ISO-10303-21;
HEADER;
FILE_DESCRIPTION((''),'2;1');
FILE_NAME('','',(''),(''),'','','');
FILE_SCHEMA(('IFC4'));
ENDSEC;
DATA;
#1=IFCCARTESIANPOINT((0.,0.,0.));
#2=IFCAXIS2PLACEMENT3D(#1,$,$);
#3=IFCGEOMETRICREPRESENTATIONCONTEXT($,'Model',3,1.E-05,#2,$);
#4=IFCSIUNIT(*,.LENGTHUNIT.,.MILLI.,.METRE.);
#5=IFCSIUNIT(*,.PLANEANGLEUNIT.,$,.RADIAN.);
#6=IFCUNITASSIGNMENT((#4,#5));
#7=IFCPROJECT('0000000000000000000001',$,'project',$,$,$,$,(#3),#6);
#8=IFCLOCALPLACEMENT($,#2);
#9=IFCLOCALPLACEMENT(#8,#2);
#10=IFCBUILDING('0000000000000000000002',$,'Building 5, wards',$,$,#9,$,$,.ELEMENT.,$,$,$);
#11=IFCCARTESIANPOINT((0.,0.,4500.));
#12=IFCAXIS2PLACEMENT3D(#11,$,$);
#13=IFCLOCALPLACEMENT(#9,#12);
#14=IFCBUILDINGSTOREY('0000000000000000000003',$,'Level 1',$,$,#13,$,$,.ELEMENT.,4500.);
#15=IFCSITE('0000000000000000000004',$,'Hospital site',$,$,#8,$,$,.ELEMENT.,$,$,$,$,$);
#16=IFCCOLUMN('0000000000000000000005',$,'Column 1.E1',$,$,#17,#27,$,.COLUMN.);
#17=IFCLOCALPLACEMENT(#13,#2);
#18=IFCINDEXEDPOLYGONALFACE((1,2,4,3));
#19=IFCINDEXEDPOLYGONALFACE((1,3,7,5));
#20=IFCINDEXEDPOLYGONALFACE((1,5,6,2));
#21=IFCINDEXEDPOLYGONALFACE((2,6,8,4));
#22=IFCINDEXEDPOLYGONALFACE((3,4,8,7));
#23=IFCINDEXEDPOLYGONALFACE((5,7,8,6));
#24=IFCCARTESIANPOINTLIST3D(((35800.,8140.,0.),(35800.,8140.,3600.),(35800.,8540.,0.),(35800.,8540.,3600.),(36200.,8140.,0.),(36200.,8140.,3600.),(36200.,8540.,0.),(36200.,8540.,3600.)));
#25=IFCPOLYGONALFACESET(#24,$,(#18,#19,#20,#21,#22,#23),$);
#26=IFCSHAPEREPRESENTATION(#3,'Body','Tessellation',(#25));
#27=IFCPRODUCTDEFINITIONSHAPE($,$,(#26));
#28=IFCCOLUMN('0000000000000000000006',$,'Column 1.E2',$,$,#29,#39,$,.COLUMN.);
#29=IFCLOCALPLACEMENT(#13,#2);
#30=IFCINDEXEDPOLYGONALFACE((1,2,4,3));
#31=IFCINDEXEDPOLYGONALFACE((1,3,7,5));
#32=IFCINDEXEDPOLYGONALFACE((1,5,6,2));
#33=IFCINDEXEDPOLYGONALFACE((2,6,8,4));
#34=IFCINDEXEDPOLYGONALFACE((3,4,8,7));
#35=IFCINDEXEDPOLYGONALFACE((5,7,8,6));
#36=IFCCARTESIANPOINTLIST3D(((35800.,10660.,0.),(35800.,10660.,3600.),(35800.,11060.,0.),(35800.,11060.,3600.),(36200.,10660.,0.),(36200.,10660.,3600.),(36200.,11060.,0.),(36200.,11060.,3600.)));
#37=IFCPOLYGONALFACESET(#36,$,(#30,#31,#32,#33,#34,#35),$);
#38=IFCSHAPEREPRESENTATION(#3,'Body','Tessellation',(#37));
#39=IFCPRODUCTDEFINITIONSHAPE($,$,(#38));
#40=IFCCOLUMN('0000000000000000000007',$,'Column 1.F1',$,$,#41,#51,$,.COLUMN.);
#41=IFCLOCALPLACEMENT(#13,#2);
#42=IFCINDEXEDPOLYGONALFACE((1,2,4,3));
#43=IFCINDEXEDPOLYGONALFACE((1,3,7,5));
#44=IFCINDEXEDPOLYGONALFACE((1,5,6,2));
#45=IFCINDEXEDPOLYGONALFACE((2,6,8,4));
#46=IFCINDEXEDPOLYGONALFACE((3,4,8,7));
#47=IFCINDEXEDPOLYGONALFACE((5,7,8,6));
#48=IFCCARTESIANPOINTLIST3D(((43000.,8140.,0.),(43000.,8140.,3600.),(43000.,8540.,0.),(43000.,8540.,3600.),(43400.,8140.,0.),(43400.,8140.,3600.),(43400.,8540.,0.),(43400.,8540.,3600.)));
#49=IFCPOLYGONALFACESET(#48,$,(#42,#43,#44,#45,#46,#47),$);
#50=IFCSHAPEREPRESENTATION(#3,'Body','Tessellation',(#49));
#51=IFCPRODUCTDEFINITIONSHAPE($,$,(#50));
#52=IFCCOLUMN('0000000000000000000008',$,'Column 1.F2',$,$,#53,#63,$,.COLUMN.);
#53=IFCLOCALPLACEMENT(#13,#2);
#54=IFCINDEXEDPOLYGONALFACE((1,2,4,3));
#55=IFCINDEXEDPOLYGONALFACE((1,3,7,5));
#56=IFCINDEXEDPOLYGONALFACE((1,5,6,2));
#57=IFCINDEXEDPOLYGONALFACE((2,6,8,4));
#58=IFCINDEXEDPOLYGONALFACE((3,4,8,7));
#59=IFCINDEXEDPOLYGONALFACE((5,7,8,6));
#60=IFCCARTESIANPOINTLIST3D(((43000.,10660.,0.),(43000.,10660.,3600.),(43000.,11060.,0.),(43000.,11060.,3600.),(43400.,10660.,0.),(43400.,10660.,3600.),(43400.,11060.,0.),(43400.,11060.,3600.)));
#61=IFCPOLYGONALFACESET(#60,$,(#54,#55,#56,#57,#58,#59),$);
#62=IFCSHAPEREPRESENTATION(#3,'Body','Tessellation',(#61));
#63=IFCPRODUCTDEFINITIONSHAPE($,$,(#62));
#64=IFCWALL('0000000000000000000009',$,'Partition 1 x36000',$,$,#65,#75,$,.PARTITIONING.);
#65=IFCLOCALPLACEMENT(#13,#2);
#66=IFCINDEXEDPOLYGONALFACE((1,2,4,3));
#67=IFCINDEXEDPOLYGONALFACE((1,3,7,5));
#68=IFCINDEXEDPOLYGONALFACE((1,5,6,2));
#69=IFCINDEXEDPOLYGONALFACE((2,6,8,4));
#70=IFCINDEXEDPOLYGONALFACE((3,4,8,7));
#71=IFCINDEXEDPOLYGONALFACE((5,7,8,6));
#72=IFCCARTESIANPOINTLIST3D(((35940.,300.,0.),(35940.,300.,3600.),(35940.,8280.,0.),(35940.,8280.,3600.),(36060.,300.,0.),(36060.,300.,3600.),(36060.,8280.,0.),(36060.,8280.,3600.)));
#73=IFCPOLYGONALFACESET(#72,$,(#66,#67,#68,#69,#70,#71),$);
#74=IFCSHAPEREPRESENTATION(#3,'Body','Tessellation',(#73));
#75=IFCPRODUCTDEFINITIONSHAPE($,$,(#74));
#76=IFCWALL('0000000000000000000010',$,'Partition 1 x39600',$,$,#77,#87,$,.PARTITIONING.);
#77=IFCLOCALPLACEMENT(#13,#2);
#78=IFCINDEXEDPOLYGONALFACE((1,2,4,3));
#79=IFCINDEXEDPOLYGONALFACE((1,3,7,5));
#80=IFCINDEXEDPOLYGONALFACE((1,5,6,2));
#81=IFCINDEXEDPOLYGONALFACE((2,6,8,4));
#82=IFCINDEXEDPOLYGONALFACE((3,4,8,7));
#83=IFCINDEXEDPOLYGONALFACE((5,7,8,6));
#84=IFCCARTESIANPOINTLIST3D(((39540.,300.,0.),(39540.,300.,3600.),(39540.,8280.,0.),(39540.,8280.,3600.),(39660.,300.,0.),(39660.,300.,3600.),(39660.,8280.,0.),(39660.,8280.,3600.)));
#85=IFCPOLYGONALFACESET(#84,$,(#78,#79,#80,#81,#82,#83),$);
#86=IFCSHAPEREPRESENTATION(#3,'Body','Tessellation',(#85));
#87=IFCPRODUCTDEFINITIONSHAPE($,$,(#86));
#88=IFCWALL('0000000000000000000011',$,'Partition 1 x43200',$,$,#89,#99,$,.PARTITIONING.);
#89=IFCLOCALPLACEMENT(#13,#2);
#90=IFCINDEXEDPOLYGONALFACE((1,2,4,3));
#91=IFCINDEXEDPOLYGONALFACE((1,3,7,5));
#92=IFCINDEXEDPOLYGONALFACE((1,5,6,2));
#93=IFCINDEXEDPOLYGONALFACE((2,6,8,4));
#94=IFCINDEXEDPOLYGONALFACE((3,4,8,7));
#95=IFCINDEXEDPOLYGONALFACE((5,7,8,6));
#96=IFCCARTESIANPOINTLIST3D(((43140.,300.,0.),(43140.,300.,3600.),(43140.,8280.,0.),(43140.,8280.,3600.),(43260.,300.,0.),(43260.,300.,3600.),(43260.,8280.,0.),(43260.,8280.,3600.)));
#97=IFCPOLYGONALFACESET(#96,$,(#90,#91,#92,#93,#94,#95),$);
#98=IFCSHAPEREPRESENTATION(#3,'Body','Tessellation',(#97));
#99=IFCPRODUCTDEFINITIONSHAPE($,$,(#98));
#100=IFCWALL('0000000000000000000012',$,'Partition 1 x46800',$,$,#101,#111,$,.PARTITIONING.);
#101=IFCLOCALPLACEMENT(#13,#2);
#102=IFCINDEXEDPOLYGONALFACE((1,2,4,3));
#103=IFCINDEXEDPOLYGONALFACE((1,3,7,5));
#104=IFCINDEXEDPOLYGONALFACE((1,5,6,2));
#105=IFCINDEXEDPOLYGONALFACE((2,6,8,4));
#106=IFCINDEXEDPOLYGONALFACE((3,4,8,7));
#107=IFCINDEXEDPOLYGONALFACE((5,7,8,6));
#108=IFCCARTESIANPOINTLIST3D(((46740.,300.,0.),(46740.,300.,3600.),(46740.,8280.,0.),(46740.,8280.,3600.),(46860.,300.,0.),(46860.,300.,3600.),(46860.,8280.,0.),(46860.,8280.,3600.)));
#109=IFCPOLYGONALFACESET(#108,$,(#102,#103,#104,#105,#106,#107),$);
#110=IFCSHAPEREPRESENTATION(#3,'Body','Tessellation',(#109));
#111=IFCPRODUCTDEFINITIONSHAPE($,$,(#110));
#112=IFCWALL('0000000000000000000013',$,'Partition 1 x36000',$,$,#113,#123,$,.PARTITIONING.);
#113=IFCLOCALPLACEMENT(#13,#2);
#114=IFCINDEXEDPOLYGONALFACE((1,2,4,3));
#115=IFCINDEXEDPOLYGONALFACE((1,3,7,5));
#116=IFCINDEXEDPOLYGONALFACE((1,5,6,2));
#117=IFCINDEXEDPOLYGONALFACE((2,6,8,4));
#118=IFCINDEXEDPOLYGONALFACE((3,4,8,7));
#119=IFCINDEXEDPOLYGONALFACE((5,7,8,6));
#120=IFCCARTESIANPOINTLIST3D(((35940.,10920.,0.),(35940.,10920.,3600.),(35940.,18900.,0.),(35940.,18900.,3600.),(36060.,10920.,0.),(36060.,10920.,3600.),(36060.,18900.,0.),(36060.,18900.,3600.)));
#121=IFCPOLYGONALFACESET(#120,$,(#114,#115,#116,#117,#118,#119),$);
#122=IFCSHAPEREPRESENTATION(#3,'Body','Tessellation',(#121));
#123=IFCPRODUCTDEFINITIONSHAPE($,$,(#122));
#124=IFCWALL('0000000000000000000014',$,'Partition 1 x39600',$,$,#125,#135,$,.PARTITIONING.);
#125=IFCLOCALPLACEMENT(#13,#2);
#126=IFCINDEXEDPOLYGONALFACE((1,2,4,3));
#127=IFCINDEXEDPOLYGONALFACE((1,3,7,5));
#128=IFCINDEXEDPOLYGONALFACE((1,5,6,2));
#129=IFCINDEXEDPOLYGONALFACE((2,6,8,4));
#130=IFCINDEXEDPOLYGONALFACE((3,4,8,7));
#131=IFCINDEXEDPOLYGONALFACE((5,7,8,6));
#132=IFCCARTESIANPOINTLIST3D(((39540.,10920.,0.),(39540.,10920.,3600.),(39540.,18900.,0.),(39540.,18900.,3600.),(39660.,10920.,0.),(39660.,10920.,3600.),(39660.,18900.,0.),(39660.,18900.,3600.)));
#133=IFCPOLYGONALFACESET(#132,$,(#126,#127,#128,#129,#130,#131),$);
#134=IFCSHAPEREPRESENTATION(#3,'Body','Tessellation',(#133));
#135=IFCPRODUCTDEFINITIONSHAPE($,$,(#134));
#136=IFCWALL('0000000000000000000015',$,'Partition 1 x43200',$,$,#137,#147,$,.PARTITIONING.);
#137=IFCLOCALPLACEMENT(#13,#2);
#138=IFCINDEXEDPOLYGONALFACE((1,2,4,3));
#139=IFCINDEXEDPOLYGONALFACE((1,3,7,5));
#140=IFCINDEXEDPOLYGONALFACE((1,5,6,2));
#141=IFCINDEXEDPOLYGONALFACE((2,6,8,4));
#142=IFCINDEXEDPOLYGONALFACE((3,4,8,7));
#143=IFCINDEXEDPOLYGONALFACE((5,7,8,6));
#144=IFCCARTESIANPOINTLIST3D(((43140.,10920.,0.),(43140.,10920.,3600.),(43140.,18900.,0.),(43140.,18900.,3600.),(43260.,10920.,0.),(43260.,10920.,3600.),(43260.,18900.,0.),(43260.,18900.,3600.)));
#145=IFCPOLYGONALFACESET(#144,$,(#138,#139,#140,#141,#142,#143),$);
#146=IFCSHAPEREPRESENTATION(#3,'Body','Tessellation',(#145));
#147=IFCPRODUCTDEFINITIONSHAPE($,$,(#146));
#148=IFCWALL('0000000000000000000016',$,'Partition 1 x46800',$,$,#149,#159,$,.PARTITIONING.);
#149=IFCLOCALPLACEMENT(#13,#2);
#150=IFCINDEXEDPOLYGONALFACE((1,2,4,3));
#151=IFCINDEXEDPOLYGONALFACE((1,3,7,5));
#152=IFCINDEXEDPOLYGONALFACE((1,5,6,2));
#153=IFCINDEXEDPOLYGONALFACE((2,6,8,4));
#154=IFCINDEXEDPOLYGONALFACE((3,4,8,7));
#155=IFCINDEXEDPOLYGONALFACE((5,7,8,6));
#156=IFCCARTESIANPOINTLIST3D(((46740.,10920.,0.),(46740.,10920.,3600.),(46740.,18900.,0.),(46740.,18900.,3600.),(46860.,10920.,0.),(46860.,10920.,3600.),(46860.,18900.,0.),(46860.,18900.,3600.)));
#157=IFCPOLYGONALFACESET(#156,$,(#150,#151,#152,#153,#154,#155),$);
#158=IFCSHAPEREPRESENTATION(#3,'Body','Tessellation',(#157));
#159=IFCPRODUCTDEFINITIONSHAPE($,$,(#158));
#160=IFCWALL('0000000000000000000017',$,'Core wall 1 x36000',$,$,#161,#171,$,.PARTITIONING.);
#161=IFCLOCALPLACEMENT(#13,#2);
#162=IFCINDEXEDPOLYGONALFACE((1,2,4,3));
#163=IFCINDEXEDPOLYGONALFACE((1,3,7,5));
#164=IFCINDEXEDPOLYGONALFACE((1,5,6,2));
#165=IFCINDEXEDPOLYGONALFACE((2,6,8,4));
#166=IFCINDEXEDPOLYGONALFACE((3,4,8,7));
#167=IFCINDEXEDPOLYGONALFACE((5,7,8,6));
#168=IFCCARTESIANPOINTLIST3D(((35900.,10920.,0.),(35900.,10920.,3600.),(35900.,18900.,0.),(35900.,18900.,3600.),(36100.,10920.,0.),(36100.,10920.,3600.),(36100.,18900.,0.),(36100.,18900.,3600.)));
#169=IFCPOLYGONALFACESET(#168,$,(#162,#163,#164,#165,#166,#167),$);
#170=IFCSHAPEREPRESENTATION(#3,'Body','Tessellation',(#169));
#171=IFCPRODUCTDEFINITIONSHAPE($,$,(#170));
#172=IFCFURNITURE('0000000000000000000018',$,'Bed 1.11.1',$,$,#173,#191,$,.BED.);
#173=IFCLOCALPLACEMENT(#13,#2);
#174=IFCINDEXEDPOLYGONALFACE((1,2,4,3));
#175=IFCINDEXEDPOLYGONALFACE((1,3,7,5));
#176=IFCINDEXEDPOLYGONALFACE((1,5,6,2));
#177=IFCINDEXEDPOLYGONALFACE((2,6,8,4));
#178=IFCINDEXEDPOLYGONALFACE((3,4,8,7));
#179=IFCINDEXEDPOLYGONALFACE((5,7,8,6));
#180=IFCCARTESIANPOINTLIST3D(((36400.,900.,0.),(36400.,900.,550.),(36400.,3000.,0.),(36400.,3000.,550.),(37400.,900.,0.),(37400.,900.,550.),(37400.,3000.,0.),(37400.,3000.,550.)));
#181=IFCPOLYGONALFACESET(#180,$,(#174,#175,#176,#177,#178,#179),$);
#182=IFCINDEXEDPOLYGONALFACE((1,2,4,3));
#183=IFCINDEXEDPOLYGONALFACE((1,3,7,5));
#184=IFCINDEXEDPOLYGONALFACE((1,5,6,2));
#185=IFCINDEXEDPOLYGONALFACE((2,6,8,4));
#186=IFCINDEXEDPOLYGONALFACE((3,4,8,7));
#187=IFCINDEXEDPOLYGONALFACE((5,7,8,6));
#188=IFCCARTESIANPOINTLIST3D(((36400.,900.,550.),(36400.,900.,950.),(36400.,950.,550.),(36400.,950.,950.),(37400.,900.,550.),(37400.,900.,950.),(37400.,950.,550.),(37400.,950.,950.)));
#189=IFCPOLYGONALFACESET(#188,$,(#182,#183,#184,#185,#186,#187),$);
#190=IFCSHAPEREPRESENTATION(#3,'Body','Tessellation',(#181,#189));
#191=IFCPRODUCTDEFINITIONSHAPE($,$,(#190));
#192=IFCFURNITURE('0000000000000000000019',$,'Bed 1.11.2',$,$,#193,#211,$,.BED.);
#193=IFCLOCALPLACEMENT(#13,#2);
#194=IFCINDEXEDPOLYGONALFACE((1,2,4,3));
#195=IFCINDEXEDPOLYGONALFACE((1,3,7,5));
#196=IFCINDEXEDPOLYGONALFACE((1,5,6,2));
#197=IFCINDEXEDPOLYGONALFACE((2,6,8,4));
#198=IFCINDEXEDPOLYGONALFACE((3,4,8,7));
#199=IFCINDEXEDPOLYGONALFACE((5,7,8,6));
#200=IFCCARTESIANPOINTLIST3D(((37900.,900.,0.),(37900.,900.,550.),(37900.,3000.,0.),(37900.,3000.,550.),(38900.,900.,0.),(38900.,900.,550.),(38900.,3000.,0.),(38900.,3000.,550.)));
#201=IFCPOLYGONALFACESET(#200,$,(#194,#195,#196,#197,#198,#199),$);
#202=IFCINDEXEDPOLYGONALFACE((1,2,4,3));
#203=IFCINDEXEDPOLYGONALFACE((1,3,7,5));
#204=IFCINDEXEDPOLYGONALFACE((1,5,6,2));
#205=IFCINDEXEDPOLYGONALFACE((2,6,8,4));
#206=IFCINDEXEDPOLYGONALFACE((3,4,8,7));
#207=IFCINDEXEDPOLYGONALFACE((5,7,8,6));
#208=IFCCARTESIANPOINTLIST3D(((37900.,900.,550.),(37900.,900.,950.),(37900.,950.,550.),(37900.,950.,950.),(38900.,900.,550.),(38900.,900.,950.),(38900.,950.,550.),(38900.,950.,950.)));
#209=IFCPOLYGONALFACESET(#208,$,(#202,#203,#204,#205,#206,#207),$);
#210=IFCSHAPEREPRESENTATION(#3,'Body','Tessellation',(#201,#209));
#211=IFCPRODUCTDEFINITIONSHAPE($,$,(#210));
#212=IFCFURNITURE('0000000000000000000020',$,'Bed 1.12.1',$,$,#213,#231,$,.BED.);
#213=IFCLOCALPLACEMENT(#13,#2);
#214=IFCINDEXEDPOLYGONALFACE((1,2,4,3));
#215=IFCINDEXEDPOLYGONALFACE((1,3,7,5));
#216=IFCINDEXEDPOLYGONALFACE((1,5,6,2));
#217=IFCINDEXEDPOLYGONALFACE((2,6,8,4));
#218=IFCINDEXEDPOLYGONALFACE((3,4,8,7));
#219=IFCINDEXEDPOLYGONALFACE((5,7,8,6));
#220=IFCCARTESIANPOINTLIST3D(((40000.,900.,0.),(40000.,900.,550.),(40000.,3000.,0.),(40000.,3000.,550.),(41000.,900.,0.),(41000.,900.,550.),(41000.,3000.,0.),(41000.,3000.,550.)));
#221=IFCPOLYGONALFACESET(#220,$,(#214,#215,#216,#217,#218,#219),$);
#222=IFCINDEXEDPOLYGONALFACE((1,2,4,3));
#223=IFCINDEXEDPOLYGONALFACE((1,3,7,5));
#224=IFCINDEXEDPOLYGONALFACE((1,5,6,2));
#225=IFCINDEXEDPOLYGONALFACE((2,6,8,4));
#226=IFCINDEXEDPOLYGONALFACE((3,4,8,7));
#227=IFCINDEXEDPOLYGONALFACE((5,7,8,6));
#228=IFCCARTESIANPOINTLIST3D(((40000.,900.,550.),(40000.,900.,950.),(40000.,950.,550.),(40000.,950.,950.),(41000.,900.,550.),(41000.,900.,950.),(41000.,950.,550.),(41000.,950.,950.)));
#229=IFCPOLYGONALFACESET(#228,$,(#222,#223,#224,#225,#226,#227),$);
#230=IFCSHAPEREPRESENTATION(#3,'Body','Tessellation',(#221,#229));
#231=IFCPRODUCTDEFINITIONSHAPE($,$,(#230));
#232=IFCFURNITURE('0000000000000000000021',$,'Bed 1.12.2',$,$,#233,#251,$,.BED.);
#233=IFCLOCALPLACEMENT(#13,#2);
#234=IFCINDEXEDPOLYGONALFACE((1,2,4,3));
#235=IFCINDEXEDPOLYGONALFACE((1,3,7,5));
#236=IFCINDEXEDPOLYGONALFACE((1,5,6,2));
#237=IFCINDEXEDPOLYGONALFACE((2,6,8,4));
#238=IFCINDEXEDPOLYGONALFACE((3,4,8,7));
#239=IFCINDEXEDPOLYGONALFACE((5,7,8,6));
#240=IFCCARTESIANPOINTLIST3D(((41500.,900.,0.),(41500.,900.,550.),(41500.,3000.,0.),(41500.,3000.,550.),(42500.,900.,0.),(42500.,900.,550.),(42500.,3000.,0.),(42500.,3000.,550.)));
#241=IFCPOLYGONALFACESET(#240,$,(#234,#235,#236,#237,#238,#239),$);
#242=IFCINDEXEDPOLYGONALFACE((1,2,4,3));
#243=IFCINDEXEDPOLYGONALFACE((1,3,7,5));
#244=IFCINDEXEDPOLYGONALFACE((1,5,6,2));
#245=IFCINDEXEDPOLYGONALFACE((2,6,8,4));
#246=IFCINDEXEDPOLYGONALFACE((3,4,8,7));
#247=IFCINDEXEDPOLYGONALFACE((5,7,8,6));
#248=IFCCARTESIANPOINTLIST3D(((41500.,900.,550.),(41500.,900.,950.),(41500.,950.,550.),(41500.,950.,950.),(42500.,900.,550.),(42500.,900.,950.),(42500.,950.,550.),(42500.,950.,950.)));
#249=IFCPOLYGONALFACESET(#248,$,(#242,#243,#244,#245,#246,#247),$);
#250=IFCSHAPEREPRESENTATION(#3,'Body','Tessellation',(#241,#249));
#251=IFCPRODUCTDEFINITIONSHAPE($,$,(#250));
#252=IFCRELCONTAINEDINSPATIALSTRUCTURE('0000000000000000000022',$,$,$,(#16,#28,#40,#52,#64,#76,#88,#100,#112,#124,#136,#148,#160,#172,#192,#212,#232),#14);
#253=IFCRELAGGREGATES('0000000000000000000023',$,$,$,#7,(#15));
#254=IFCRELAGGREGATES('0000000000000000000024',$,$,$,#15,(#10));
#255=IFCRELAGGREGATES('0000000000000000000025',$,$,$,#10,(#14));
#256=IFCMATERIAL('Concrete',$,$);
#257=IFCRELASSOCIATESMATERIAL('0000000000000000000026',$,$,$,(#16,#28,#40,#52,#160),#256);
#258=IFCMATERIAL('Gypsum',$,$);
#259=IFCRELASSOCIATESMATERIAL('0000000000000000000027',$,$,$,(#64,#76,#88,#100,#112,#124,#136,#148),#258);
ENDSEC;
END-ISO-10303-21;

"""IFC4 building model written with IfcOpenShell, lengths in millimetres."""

from ifc_helpers import new_model, si_unit, frame, frame_2d, origin, origin_2d, place, context, project, spatial, rectangle, extrude, material, element, save


model = new_model("IFC4")

# Units and contexts
model_context = context("Model", 3, precision=1e-05, world=origin())
ifc_project = project(units=[si_unit("LENGTHUNIT", "METRE", prefix="MILLI"), si_unit("PLANEANGLEUNIT", "RADIAN")], contexts=[model_context])

# Site, building, storey
site_placement = place(None, origin())
site = spatial("IfcSite", under=ifc_project, at=site_placement, Name="Hospital site", CompositionType="ELEMENT")
building_placement = place(site_placement, origin())
building = spatial("IfcBuilding", under=site, at=building_placement, Name="Building 5, wards", CompositionType="ELEMENT")
storey_placement = place(building_placement, frame((0.0, 0.0, 4500.0)))
storey = spatial("IfcBuildingStorey", under=building, at=storey_placement, Name="Level 1", CompositionType="ELEMENT", Elevation=4500.0)

# Columns
ifc_material_1 = material(Name="Concrete")
for number, where, name in (
    (1, (36000.0, 8340.0, 0.0), "Column 1.E1"),
    (2, (36000.0, 10860.0, 0.0), "Column 1.E2"),
    (3, (43200.0, 8340.0, 0.0), "Column 1.F1"),
    (4, (43200.0, 10860.0, 0.0), "Column 1.F2"),
):
    element("IfcColumn", number, at=place(storey_placement, frame(where)), inside=storey, material=ifc_material_1, Name=name, PredefinedType="COLUMN", context=model_context, shape_type="SweptSolid", body=[
        extrude(rectangle(XDim=400.0, YDim=400.0, at=origin_2d()), origin(), (0.0, 0.0, 1.0), 3600.0),
    ])

# Walls
ifc_material_2 = material(Name="Gypsum")
for number, where, x_axis, name in (
    (5, (36060.0, 300.0, 0.0), (0.0, 1.0, 0.0), "Partition 1 x36000"),
    (6, (39660.0, 300.0, 0.0), (0.0, 1.0, 0.0), "Partition 1 x39600"),
    (7, (43260.0, 300.0, 0.0), (0.0, 1.0, 0.0), "Partition 1 x43200"),
    (8, (46860.0, 300.0, 0.0), (0.0, 1.0, 0.0), "Partition 1 x46800"),
    (9, (36060.0, 10920.0, 0.0), (0.0, 1.0, 0.0), "Partition 1 x36000"),
    (10, (39660.0, 10920.0, 0.0), (0.0, 1.0, 0.0), "Partition 1 x39600"),
    (11, (43260.0, 10920.0, 0.0), (0.0, 1.0, 0.0), "Partition 1 x43200"),
    (12, (46860.0, 10920.0, 0.0), (0.0, 1.0, 0.0), "Partition 1 x46800"),
):
    element("IfcWall", number, at=place(storey_placement, frame(where, x_axis=x_axis)), inside=storey, material=ifc_material_2, Name=name, PredefinedType="PARTITIONING", context=model_context, shape_type="SweptSolid", body=[
        extrude(rectangle(XDim=7980.0, YDim=120.0, at=frame_2d((3990.0, 60.0))), origin(), (0.0, 0.0, 1.0), 3600.0),
    ])
wall_placement = place(storey_placement, frame((36100.0, 10920.0, 0.0), x_axis=(0.0, 1.0, 0.0)))
element("IfcWall", 13, at=wall_placement, inside=storey, material=ifc_material_1, Name="Core wall 1 x36000", PredefinedType="PARTITIONING", context=model_context, shape_type="SweptSolid", body=[
    extrude(rectangle(XDim=7980.0, YDim=200.0, at=frame_2d((3990.0, 100.0))), origin(), (0.0, 0.0, 1.0), 3600.0),
])

# Furniture
for number, where, name in (
    (14, (36400.0, 900.0, 0.0), "Bed 1.11.1"),
    (15, (37900.0, 900.0, 0.0), "Bed 1.11.2"),
    (16, (40000.0, 900.0, 0.0), "Bed 1.12.1"),
    (17, (41500.0, 900.0, 0.0), "Bed 1.12.2"),
):
    element("IfcFurniture", number, at=place(storey_placement, frame(where)), inside=storey, Name=name, PredefinedType="BED", context=model_context, shape_type="SweptSolid", body=[
        extrude(rectangle(XDim=1000.0, YDim=2100.0, at=frame_2d((500.0, 1050.0))), origin(), (0.0, 0.0, 1.0), 550.0),
        extrude(rectangle(XDim=1000.0, YDim=50.0, at=frame_2d((500.0, 25.0))), frame((0.0, 0.0, 550.0)), (0.0, 0.0, 1.0), 400.0),
    ])

save(model, "model.ifc")
